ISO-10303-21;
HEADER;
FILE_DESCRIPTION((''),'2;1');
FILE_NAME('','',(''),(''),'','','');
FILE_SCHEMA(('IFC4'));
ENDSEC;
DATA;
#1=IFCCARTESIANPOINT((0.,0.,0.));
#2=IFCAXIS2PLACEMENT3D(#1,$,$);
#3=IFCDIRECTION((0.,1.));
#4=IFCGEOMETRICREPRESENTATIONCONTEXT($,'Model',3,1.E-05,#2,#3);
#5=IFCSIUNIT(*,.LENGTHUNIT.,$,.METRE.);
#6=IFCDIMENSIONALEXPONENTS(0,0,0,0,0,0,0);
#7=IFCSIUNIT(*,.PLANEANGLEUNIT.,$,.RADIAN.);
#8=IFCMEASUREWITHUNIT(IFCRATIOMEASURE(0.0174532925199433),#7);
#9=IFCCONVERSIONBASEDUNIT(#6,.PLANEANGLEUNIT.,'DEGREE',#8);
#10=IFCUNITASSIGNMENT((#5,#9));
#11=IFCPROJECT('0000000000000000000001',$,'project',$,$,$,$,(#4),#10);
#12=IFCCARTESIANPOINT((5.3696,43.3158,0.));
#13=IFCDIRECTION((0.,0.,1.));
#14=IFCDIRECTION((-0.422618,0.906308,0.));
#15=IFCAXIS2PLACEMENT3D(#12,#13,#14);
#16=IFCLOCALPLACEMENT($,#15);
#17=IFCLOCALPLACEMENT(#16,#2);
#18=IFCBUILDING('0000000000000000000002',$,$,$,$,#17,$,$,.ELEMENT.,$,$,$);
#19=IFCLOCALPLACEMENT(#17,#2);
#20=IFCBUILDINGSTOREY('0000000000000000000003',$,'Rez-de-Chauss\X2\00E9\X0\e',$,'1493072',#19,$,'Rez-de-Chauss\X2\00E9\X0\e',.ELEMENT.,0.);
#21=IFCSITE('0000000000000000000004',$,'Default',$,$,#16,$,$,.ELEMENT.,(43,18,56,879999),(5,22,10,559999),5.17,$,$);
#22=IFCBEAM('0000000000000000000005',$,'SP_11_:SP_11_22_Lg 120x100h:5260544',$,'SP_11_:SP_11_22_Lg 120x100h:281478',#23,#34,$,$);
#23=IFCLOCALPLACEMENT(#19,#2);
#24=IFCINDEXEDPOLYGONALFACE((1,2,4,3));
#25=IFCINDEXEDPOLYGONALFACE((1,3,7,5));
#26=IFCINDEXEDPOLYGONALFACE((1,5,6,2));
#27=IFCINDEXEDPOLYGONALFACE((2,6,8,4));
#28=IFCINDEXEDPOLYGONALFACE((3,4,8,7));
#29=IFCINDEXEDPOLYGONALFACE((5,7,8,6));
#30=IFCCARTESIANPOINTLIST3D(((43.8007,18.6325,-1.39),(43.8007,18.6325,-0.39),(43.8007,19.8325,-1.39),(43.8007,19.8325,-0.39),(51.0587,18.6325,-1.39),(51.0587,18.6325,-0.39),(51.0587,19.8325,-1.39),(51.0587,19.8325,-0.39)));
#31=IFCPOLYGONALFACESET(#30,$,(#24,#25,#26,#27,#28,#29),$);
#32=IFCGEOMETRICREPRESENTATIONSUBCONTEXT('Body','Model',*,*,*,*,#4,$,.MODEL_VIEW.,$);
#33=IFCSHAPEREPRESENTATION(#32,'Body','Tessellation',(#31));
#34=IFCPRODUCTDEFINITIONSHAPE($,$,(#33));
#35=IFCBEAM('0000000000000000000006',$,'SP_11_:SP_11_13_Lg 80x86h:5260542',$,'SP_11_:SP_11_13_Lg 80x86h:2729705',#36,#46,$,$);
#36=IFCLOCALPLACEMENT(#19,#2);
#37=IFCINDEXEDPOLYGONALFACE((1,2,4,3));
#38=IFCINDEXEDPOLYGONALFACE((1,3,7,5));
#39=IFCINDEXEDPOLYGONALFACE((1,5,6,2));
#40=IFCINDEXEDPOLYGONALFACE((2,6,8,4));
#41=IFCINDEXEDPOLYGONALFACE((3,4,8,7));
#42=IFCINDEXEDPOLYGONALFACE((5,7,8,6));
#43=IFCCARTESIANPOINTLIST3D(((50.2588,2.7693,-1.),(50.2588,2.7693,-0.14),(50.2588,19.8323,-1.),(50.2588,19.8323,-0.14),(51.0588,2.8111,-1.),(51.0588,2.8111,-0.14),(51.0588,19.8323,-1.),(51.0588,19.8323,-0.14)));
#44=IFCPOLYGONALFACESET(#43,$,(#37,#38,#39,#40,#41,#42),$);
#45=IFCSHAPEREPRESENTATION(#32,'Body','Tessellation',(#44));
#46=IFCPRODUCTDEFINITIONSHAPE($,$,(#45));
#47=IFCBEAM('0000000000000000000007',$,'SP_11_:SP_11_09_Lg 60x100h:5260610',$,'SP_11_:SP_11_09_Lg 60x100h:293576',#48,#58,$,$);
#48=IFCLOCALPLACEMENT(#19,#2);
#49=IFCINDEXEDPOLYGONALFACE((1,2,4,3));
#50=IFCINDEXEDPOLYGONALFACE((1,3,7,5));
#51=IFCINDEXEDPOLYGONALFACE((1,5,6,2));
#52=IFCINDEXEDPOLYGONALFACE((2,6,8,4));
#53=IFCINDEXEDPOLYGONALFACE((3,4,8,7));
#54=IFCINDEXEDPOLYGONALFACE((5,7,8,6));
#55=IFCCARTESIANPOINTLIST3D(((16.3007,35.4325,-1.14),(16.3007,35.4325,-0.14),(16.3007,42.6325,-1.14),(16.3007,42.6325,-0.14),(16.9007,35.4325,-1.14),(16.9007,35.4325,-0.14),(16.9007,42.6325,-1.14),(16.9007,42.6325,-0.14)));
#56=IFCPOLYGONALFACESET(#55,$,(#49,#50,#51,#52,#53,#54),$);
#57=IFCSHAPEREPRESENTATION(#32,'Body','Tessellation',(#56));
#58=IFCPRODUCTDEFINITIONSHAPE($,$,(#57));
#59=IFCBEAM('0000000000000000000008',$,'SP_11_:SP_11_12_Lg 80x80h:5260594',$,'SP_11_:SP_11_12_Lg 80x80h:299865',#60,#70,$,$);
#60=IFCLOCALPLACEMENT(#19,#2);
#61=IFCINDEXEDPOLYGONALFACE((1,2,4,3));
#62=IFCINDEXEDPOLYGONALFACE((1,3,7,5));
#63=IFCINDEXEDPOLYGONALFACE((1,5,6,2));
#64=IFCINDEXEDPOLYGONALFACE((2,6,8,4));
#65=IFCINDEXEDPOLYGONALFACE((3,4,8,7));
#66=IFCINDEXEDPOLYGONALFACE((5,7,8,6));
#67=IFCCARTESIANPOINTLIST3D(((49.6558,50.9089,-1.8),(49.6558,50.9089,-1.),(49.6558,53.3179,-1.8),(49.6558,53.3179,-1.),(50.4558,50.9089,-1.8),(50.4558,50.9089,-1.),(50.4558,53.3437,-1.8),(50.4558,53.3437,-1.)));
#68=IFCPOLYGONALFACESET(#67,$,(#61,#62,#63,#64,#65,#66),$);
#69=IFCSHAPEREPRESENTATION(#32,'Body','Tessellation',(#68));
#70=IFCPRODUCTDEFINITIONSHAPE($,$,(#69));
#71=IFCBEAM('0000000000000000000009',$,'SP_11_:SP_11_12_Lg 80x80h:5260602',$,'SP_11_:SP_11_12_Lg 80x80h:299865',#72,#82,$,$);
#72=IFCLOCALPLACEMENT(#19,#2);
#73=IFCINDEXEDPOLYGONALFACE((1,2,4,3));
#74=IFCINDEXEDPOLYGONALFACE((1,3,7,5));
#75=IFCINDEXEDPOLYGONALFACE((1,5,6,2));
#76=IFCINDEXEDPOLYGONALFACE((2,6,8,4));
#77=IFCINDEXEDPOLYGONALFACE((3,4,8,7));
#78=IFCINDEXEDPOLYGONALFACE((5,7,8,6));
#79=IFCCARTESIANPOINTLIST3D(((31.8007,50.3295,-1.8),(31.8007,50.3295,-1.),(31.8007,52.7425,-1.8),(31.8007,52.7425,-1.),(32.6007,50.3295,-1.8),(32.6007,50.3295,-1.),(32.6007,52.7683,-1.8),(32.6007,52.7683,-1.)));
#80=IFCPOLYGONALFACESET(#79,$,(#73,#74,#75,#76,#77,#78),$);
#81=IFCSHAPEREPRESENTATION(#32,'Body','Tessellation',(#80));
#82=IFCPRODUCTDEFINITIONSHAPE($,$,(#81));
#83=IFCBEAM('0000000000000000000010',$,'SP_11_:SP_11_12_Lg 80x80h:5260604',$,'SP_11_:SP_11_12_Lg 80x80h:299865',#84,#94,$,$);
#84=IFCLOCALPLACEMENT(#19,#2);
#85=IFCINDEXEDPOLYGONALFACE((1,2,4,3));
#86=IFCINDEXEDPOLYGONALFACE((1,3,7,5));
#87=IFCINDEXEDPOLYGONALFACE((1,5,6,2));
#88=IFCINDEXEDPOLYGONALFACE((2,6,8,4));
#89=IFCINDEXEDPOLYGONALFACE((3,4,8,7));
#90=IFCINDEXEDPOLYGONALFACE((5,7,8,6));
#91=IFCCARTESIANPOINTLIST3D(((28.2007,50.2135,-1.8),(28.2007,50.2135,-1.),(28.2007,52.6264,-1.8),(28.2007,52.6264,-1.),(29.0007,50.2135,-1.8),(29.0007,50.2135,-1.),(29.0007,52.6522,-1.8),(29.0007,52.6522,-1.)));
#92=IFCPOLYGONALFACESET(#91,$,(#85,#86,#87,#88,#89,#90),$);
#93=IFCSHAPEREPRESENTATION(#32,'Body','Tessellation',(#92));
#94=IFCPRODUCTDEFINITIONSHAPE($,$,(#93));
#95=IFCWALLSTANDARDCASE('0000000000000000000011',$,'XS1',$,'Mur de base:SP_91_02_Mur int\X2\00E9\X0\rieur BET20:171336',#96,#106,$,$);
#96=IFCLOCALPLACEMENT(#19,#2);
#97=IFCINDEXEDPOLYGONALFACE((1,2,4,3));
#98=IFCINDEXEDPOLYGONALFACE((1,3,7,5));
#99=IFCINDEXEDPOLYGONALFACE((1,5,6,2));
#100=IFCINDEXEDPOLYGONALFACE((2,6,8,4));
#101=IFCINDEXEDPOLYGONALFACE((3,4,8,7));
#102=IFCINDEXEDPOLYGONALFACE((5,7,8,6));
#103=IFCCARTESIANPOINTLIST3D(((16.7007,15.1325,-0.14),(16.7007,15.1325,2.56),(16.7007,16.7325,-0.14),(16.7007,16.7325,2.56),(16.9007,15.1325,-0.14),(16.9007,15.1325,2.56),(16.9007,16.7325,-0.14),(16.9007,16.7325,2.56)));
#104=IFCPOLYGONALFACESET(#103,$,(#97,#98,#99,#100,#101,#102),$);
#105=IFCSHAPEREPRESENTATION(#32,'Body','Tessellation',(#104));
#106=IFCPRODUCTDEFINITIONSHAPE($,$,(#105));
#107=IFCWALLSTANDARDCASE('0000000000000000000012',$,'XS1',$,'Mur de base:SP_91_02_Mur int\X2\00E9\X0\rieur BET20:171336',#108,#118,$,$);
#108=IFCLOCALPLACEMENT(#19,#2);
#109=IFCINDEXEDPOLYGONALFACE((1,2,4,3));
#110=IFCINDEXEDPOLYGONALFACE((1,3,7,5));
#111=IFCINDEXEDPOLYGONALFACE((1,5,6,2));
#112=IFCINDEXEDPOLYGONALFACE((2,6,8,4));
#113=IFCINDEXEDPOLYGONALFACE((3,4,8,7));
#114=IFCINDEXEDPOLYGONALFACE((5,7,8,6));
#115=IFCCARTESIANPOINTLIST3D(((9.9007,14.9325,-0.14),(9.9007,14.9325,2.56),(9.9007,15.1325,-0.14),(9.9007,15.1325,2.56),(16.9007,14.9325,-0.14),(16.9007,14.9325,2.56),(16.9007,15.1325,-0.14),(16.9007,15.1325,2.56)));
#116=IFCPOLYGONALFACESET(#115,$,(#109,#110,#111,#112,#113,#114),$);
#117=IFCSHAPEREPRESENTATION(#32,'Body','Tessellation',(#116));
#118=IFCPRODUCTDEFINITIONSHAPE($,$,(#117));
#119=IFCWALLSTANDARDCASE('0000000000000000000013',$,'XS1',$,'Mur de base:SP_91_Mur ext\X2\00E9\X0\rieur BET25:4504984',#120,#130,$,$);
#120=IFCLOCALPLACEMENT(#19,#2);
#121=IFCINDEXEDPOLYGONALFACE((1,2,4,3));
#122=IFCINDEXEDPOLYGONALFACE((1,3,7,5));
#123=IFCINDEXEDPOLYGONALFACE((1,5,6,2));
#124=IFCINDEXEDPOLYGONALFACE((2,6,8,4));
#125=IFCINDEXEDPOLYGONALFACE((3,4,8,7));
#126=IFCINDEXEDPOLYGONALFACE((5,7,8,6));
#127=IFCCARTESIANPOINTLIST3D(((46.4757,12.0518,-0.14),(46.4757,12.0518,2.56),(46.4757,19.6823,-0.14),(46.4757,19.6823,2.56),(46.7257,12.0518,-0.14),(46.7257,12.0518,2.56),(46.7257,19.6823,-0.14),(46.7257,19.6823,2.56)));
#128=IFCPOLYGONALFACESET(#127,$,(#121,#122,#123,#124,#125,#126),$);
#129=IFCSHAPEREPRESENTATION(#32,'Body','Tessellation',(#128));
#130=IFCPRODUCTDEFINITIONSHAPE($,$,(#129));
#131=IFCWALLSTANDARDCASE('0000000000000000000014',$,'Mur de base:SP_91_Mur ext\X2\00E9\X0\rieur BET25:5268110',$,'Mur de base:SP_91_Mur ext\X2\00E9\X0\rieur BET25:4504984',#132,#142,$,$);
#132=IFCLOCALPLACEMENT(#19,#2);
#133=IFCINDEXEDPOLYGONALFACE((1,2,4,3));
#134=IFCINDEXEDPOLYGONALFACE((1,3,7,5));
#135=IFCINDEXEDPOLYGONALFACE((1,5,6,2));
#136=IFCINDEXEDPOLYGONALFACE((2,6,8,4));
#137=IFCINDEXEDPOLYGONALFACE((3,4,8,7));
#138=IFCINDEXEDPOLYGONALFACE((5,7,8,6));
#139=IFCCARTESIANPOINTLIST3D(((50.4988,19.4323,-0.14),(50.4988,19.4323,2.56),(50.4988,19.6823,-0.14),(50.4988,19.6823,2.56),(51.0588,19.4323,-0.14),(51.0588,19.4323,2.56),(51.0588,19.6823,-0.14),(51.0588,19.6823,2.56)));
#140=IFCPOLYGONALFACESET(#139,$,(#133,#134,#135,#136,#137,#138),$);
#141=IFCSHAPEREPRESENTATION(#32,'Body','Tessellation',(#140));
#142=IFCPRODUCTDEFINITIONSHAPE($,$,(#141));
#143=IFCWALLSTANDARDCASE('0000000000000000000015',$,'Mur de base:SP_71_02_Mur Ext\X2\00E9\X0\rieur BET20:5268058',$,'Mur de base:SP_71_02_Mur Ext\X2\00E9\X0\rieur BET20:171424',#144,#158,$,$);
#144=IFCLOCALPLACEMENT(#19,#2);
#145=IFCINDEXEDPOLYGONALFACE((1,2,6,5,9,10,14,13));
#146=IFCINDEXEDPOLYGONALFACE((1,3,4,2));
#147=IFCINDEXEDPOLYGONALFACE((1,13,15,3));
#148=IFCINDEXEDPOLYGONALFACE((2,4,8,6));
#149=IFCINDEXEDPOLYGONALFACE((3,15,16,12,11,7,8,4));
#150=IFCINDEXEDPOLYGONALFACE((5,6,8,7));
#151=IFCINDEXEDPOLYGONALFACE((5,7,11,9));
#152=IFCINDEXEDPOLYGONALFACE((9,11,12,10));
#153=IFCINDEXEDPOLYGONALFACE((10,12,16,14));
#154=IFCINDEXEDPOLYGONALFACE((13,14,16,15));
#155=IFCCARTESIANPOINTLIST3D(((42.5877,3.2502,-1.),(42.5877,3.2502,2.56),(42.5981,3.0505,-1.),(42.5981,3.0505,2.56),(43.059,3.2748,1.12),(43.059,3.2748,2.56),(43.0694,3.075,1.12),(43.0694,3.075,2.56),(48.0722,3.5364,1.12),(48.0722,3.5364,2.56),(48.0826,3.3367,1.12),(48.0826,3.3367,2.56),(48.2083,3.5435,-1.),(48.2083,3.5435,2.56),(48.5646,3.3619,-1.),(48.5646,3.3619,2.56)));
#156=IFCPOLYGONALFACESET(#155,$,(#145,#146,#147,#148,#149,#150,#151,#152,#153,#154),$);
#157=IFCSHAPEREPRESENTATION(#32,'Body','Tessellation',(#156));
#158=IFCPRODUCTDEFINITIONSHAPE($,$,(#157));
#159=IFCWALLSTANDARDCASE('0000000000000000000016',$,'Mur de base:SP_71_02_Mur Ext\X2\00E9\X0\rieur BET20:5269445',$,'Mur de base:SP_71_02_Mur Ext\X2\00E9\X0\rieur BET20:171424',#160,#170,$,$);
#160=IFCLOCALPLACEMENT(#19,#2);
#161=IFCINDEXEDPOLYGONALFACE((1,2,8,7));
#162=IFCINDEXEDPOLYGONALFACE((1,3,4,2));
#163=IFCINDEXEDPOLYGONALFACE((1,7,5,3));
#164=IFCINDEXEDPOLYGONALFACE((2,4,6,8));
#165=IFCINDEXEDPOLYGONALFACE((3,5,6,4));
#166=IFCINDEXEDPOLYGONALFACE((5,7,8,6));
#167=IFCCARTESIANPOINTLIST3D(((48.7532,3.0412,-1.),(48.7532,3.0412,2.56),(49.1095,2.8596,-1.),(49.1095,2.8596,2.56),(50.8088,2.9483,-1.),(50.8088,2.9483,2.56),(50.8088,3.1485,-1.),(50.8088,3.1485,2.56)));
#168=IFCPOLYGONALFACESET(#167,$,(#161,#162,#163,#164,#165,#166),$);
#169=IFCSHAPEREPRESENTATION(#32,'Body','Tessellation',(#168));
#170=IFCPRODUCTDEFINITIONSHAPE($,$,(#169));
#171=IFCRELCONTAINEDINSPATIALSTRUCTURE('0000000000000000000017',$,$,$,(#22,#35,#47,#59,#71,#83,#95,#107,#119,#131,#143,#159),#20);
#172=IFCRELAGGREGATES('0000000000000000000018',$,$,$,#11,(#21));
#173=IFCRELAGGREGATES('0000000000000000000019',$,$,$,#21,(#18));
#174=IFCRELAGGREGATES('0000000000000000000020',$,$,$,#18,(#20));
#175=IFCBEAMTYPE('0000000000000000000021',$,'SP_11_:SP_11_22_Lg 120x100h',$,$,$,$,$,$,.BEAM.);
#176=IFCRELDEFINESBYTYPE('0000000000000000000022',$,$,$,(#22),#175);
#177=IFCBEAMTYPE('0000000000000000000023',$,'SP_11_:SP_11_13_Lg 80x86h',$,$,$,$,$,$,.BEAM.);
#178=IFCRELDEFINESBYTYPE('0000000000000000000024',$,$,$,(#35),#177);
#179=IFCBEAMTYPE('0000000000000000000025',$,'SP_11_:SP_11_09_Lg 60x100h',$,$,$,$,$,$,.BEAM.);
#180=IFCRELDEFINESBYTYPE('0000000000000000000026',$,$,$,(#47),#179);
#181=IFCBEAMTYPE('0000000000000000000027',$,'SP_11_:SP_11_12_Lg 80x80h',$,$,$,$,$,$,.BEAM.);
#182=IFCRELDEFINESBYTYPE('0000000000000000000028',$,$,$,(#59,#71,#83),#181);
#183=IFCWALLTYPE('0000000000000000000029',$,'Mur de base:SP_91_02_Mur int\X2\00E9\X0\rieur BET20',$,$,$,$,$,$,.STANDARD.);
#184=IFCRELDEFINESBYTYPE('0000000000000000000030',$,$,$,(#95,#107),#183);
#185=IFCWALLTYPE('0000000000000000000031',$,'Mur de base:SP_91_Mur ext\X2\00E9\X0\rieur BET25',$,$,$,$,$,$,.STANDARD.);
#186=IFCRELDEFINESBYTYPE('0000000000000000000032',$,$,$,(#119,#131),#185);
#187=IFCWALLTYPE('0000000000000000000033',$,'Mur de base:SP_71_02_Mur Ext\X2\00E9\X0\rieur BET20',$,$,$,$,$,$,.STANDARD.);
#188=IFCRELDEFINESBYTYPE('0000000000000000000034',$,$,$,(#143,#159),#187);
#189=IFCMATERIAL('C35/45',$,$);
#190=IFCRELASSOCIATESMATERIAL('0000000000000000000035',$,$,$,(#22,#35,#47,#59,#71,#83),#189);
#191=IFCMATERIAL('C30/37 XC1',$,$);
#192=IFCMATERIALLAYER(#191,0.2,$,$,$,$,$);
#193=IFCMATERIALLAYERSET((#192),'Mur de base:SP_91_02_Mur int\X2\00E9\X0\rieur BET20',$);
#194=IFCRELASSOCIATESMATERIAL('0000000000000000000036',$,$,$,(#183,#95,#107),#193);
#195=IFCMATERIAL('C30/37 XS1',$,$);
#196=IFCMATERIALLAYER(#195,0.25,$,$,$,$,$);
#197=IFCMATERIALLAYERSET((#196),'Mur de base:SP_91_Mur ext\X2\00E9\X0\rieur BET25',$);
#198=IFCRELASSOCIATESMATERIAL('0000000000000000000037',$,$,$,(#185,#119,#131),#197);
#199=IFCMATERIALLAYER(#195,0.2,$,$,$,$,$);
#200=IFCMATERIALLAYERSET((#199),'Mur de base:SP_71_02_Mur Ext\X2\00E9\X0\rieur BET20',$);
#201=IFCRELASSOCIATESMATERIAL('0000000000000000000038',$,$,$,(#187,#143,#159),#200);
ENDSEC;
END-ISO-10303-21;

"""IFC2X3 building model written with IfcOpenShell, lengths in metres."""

from ifc_helpers import new_model, entity, si_unit, converted_unit, direction, frame, frame_2d, origin, origin_2d_with_axis, place, context, subcontext, project, spatial, polyline, rectangle, outline, extrude, clip, halfspace, material, layer, layer_set, layer_usage, type_object, element, save


model = new_model("IFC2X3")

# Units and contexts
model_context = context("Model", 3, precision=1e-05, world=origin(), true_north=direction((0.0, 1.0)))
body_context = subcontext(model_context, "Body", "Model", "MODEL_VIEW")
ifc_project = project(units=[si_unit("LENGTHUNIT", "METRE"), converted_unit("PLANEANGLEUNIT", "DEGREE", entity("IfcRatioMeasure", 0.0174532925199433), si_unit("PLANEANGLEUNIT", "RADIAN"), dimensions=[0, 0, 0, 0, 0, 0, 0])], contexts=[model_context])

# Site, building, storey
site_placement = place(None, frame((5.3696, 43.3158, 0.0), z_axis=(0.0, 0.0, 1.0), x_axis=(-0.422618, 0.906308, 0.0)))
site = spatial("IfcSite", under=ifc_project, at=site_placement, Name="Default", CompositionType="ELEMENT", RefLatitude=(43, 18, 56, 879999), RefLongitude=(5, 22, 10, 559999), RefElevation=5.17)
building_placement = place(site_placement, origin())
building = spatial("IfcBuilding", under=site, at=building_placement, CompositionType="ELEMENT")
storey_placement = place(building_placement, origin())
storey = spatial("IfcBuildingStorey", under=building, at=storey_placement, Name="Rez-de-Chaussée", ObjectType="1493072", LongName="Rez-de-Chaussée", CompositionType="ELEMENT", Elevation=0.0)

# Beams
ifc_material_1 = material(Name="C35/45")
beam_type_1 = type_object("IfcBeamType", Name="SP_11_:SP_11_22_Lg 120x100h", PredefinedType="BEAM")
beam_1_placement = place(storey_placement, frame((43.8007, 19.2325, -0.39)))
element("IfcBeam", 1, at=beam_1_placement, inside=storey, type_object=beam_type_1, material=ifc_material_1, Name="SP_11_:SP_11_22_Lg 120x100h:5260544", ObjectType="SP_11_:SP_11_22_Lg 120x100h:281478", context=body_context, shape_type="SweptSolid", body=[
    extrude(rectangle(XDim=1.0, YDim=1.2, at=frame_2d((0.0, 0.0), x_axis=(1.0, 0.0))), frame((0.0, 0.0, -0.5), z_axis=(1.0, 0.0, 0.0), x_axis=(0.0, 0.0, -1.0)), (0.0, 0.0, 1.0), 7.2581),
])
beam_type_2 = type_object("IfcBeamType", Name="SP_11_:SP_11_13_Lg 80x86h", PredefinedType="BEAM")
beam_2_placement = place(storey_placement, frame((50.6588, 19.8325, -0.14), z_axis=(0.0, 0.0, 1.0), x_axis=(0.0, -1.0, 0.0)))
element("IfcBeam", 2, at=beam_2_placement, inside=storey, type_object=beam_type_2, material=ifc_material_1, Name="SP_11_:SP_11_13_Lg 80x86h:5260542", ObjectType="SP_11_:SP_11_13_Lg 80x86h:2729705", context=body_context, shape_type="Clipping", body=[
    clip(extrude(rectangle(XDim=0.86, YDim=0.8, at=frame_2d((0.0, 0.0), x_axis=(1.0, 0.0))), frame((0.0002, 0.0, -0.43), z_axis=(1.0, 0.0, 0.0), x_axis=(0.0, 0.0, -1.0)), (0.0, 0.0, 1.0), 17.063), halfspace(frame((17.0203, 0.4219, -0.86), z_axis=(0.998641, 0.05212, 0.0), x_axis=(0.05212, -0.998641, 0.0)), False)),
])
beam_type_3 = type_object("IfcBeamType", Name="SP_11_:SP_11_09_Lg 60x100h", PredefinedType="BEAM")
beam_3_placement = place(storey_placement, frame((16.6007, 34.8325, -0.14), z_axis=(0.0, 0.0, 1.0), x_axis=(0.0, 1.0, 0.0)))
element("IfcBeam", 3, at=beam_3_placement, inside=storey, type_object=beam_type_3, material=ifc_material_1, Name="SP_11_:SP_11_09_Lg 60x100h:5260610", ObjectType="SP_11_:SP_11_09_Lg 60x100h:293576", context=body_context, shape_type="SweptSolid", body=[
    extrude(rectangle(XDim=1.0, YDim=0.6, at=frame_2d((0.0, 0.0), x_axis=(1.0, 0.0))), frame((0.6, 0.0, -0.5), z_axis=(1.0, 0.0, 0.0), x_axis=(0.0, 0.0, -1.0)), (0.0, 0.0, 1.0), 7.2),
])
beam_type_4 = type_object("IfcBeamType", Name="SP_11_:SP_11_12_Lg 80x80h", PredefinedType="BEAM")
beam_4_placement = place(storey_placement, frame((50.0558, 50.9087, -1.0), z_axis=(0.0, 0.0, 1.0), x_axis=(0.0, 1.0, 0.0)))
element("IfcBeam", 4, at=beam_4_placement, inside=storey, type_object=beam_type_4, material=ifc_material_1, Name="SP_11_:SP_11_12_Lg 80x80h:5260594", ObjectType="SP_11_:SP_11_12_Lg 80x80h:299865", context=body_context, shape_type="Clipping", body=[
    clip(extrude(rectangle(XDim=0.8, YDim=0.8, at=frame_2d((0.0, 0.0), x_axis=(1.0, 0.0))), frame((0.0002, 0.0, -0.4), z_axis=(1.0, 0.0, 0.0), x_axis=(0.0, 0.0, -1.0)), (0.0, 0.0, 1.0), 2.4348), halfspace(frame((2.4545, -1.0048, 0.0), z_axis=(0.999481, 0.032213, 0.0), x_axis=(-0.032213, 0.999481, 0.0)), False)),
])
beam_5_placement = place(storey_placement, frame((32.2007, 50.3295, -1.0), z_axis=(0.0, 0.0, 1.0), x_axis=(0.0, 1.0, 0.0)))
element("IfcBeam", 5, at=beam_5_placement, inside=storey, type_object=beam_type_4, material=ifc_material_1, Name="SP_11_:SP_11_12_Lg 80x80h:5260602", ObjectType="SP_11_:SP_11_12_Lg 80x80h:299865", context=body_context, shape_type="Clipping", body=[
    clip(extrude(rectangle(XDim=0.8, YDim=0.8, at=frame_2d((0.0, 0.0), x_axis=(1.0, 0.0))), frame((0.0001, 0.0, -0.4), z_axis=(1.0, 0.0, 0.0), x_axis=(0.0, 0.0, -1.0)), (0.0, 0.0, 1.0), 2.4387), halfspace(frame((3.0337, -18.8599, 0.0), z_axis=(0.999481, 0.032213, 0.0), x_axis=(-0.032213, 0.999481, 0.0)), False)),
])
beam_6_placement = place(storey_placement, frame((28.6007, 50.2135, -1.0), z_axis=(0.0, 0.0, 1.0), x_axis=(0.0, 1.0, 0.0)))
element("IfcBeam", 6, at=beam_6_placement, inside=storey, type_object=beam_type_4, material=ifc_material_1, Name="SP_11_:SP_11_12_Lg 80x80h:5260604", ObjectType="SP_11_:SP_11_12_Lg 80x80h:299865", context=body_context, shape_type="Clipping", body=[
    clip(extrude(rectangle(XDim=0.8, YDim=0.8, at=frame_2d((0.0, 0.0), x_axis=(1.0, 0.0))), frame((0.0001, 0.0, -0.4), z_axis=(1.0, 0.0, 0.0), x_axis=(0.0, 0.0, -1.0)), (0.0, 0.0, 1.0), 2.4387), halfspace(frame((3.1498, -22.4599, 0.0), z_axis=(0.999481, 0.032213, 0.0), x_axis=(-0.032213, 0.999481, 0.0)), False)),
])

# Shared definitions
ifc_material_2 = material(Name="C30/37 XS1")

# Wall
ifc_material_3 = material(Name="C30/37 XC1")
ifc_layer_1 = layer(ifc_material_3, 0.2)
ifc_layer_set_1 = layer_set([ifc_layer_1], Name="Mur de base:SP_91_02_Mur intérieur BET20")
ifc_layer_usage_1 = layer_usage(ifc_layer_set_1, "AXIS2", "NEGATIVE", 0.1)
wall_type_1 = type_object("IfcWallType", Name="Mur de base:SP_91_02_Mur intérieur BET20", PredefinedType="STANDARD", material=ifc_layer_set_1)
wall_1_placement = place(storey_placement, frame((16.8007, 16.7325, -0.14), z_axis=(0.0, 0.0, 1.0), x_axis=(0.0, -1.0, 0.0)))
element("IfcWallStandardCase", 7, at=wall_1_placement, inside=storey, type_object=wall_type_1, material=ifc_layer_usage_1, Name="XS1", ObjectType="Mur de base:SP_91_02_Mur intérieur BET20:171336", context=body_context, shape_type="Clipping", body=[
    clip(extrude(rectangle(XDim=1.6, YDim=0.2, at=frame_2d((0.8, 0.0), x_axis=(-1.0, 0.0))), origin(), (0.0, 0.0, 1.0), 2.7), halfspace(frame((0.0, 0.0, -0.14)), True)),
])

# Walls
ifc_layer_usage_2 = layer_usage(ifc_layer_set_1, "AXIS2", "NEGATIVE", 0.1)
wall_2_placement = place(storey_placement, frame((16.9007, 15.0325, -0.14), z_axis=(0.0, 0.0, 1.0), x_axis=(-1.0, 0.0, 0.0)))
element("IfcWallStandardCase", 8, at=wall_2_placement, inside=storey, type_object=wall_type_1, material=ifc_layer_usage_2, Name="XS1", ObjectType="Mur de base:SP_91_02_Mur intérieur BET20:171336", context=body_context, shape_type="Clipping", body=[
    clip(extrude(rectangle(XDim=7.0, YDim=0.2, at=frame_2d((3.5, 0.0), x_axis=(-1.0, 0.0))), origin(), (0.0, 0.0, 1.0), 2.7), halfspace(frame((0.0, 0.0, -0.14)), True)),
])
ifc_layer_2 = layer(ifc_material_2, 0.25)
ifc_layer_set_2 = layer_set([ifc_layer_2], Name="Mur de base:SP_91_Mur extérieur BET25")
ifc_layer_usage_3 = layer_usage(ifc_layer_set_2, "AXIS2", "NEGATIVE", 0.125)
wall_type_2 = type_object("IfcWallType", Name="Mur de base:SP_91_Mur extérieur BET25", PredefinedType="STANDARD", material=ifc_layer_set_2)
wall_3_placement = place(storey_placement, frame((46.6007, 19.6823, -0.14), z_axis=(0.0, 0.0, 1.0), x_axis=(0.0, -1.0, 0.0)))
element("IfcWallStandardCase", 9, at=wall_3_placement, inside=storey, type_object=wall_type_2, material=ifc_layer_usage_3, Name="XS1", ObjectType="Mur de base:SP_91_Mur extérieur BET25:4504984", context=body_context, shape_type="Clipping", body=[
    clip(extrude(rectangle(XDim=7.6306, YDim=0.25, at=frame_2d((3.8153, 0.0), x_axis=(-1.0, 0.0))), origin(), (0.0, 0.0, 1.0), 2.7), halfspace(frame((0.0, 0.0, -0.14)), True)),
])
ifc_layer_usage_4 = layer_usage(ifc_layer_set_2, "AXIS2", "NEGATIVE", 0.125)
wall_4_placement = place(storey_placement, frame((50.4988, 19.5573, -0.14)))
element("IfcWallStandardCase", 10, at=wall_4_placement, inside=storey, type_object=wall_type_2, material=ifc_layer_usage_4, Name="Mur de base:SP_91_Mur extérieur BET25:5268110", ObjectType="Mur de base:SP_91_Mur extérieur BET25:4504984", context=body_context, shape_type="Clipping", body=[
    clip(extrude(rectangle(XDim=0.56, YDim=0.25, at=frame_2d((0.28, 0.0), x_axis=(-1.0, 0.0))), origin(), (0.0, 0.0, 1.0), 2.7), halfspace(frame((0.0, 0.0, -0.14)), True)),
])

# Wall, opening
ifc_layer_3 = layer(ifc_material_2, 0.2)
ifc_layer_set_3 = layer_set([ifc_layer_3], Name="Mur de base:SP_71_02_Mur Extérieur BET20")
ifc_layer_usage_5 = layer_usage(ifc_layer_set_3, "AXIS2", "NEGATIVE", 0.1)
wall_type_3 = type_object("IfcWallType", Name="Mur de base:SP_71_02_Mur Extérieur BET20", PredefinedType="STANDARD", material=ifc_layer_set_3)
wall_5_placement = place(storey_placement, frame((42.5929, 3.1503, -1.0), z_axis=(0.0, 0.0, 1.0), x_axis=(0.998641, 0.05212, 0.0)))
wall_5 = element("IfcWallStandardCase", 11, at=wall_5_placement, inside=storey, type_object=wall_type_3, material=ifc_layer_usage_5, Name="Mur de base:SP_71_02_Mur Extérieur BET20:5268058", ObjectType="Mur de base:SP_71_02_Mur Extérieur BET20:171424", context=body_context, shape_type="Clipping", body=[
    clip(extrude(outline(polyline([(5.9747, -0.1), (5.6282, 0.1), (0.1555, 0.1), (0.0, 0.1), (0.0, -0.1), (0.2, -0.1), (5.5747, -0.1), (5.9747, -0.1)])), origin(), (0.0, 0.0, 1.0), 3.56), halfspace(frame((0.0, 0.0, -1.0)), True)),
])
opening_1_placement = place(wall_5_placement, origin())
element("IfcOpeningElement", 12, at=opening_1_placement, cuts=wall_5, ObjectType="Opening", context=body_context, shape_type="SweptSolid", body=[
    extrude(rectangle(XDim=2.24, YDim=5.02, at=origin_2d_with_axis()), frame((2.9819, -1.424, 3.24), z_axis=(0.0, 1.0, 0.0), x_axis=(0.0, 0.0, -1.0)), (0.0, 0.0, 1.0), 3.048),
])

# Wall
ifc_layer_usage_6 = layer_usage(ifc_layer_set_3, "AXIS2", "NEGATIVE", 0.1)
wall_6_placement = place(storey_placement, frame((48.7584, 2.9414, -1.0), z_axis=(0.0, 0.0, 1.0), x_axis=(0.998641, 0.05212, 0.0)))
element("IfcWallStandardCase", 13, at=wall_6_placement, inside=storey, type_object=wall_type_3, material=ifc_layer_usage_6, Name="Mur de base:SP_71_02_Mur Extérieur BET20:5269445", ObjectType="Mur de base:SP_71_02_Mur Extérieur BET20:171424", context=body_context, shape_type="Clipping", body=[
    clip(extrude(outline(polyline([(2.048, -0.1), (2.0584, 0.1), (0.4, 0.1), (0.0, 0.1), (0.3464, -0.1), (2.048, -0.1)])), origin(), (0.0, 0.0, 1.0), 3.56), halfspace(frame((0.0, 0.0, -1.0)), True)),
])

save(model, "model.ifc")
